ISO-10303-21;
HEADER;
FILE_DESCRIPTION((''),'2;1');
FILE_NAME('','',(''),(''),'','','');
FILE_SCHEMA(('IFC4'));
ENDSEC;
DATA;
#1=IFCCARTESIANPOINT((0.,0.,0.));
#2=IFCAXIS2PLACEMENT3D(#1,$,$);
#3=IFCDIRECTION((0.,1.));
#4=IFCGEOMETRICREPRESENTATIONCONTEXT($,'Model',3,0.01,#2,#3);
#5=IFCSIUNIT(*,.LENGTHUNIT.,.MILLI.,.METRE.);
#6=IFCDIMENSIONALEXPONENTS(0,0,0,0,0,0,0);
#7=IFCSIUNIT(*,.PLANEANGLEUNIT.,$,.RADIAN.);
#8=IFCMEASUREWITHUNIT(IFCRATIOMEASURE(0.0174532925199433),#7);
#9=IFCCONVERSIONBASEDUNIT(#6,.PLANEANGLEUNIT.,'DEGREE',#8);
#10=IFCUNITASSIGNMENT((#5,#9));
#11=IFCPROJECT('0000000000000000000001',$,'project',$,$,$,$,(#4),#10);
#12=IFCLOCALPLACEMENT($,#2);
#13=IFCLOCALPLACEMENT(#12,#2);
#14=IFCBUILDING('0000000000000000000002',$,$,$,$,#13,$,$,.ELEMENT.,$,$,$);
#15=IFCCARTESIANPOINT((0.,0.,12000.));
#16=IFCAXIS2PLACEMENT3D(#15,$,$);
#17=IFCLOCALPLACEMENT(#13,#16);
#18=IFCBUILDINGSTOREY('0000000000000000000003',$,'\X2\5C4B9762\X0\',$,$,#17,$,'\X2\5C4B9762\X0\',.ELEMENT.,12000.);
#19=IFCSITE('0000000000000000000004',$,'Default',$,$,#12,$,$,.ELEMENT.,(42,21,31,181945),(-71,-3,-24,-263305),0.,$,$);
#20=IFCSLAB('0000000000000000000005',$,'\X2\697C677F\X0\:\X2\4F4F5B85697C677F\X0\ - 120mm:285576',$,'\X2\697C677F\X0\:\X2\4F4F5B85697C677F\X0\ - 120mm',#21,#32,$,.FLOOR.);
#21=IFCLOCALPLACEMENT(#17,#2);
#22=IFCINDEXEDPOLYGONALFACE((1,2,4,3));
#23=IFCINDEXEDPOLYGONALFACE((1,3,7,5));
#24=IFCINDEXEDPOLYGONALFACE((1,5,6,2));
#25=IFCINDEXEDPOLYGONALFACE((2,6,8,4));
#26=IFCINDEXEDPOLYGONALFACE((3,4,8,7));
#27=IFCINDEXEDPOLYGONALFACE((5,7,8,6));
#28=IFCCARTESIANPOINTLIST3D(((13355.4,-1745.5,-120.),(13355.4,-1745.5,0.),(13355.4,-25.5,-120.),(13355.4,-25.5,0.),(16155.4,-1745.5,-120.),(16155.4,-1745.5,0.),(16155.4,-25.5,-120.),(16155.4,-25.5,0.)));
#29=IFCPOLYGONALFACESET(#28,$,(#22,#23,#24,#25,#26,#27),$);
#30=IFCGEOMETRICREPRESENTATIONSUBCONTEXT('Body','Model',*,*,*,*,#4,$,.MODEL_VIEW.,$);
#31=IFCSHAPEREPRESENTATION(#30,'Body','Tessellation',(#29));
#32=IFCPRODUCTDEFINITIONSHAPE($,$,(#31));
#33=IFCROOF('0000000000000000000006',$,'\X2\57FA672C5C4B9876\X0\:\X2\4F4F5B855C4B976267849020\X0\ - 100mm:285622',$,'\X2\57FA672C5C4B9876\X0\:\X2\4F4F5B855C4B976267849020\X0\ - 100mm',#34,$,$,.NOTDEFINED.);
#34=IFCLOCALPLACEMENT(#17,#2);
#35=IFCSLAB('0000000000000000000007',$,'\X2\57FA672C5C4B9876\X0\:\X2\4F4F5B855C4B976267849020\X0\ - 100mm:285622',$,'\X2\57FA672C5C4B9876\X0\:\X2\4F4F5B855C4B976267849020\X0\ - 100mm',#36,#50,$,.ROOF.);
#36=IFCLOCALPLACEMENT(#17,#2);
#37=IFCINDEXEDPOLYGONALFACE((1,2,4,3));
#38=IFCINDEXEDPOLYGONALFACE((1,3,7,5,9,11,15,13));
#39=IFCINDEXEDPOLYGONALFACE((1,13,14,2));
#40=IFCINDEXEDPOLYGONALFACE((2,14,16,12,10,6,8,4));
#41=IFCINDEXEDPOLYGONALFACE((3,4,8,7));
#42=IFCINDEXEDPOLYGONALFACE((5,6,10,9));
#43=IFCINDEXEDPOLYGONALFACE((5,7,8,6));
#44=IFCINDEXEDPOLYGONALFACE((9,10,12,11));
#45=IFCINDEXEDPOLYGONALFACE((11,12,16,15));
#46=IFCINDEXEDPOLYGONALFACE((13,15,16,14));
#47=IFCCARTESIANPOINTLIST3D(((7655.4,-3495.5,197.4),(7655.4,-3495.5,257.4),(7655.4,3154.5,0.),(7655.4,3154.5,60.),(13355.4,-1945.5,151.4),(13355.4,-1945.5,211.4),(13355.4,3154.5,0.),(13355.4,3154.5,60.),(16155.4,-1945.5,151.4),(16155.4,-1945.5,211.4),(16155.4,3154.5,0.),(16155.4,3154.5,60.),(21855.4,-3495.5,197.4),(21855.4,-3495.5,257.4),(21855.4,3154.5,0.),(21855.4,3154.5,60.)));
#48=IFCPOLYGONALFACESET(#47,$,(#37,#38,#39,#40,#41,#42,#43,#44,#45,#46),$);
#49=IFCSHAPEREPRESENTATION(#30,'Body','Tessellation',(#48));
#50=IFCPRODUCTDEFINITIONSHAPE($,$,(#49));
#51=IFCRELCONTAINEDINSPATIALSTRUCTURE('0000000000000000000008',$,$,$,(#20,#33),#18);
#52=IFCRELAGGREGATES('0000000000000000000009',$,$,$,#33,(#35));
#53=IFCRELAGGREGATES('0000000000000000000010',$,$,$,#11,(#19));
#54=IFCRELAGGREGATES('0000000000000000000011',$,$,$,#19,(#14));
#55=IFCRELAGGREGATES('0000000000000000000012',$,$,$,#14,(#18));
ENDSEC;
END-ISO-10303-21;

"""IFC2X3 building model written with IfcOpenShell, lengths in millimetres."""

from ifc_helpers import new_model, entity, si_unit, converted_unit, direction, frame, origin, origin_2d_with_axis, place, context, subcontext, project, spatial, polyline, rectangle, outline, extrude, element, aggregate, save


model = new_model("IFC2X3")

# Units and contexts
model_context = context("Model", 3, precision=0.01, world=origin(), true_north=direction((0.0, 1.0)))
body_context = subcontext(model_context, "Body", "Model", "MODEL_VIEW")
ifc_project = project(units=[si_unit("LENGTHUNIT", "METRE", prefix="MILLI"), converted_unit("PLANEANGLEUNIT", "DEGREE", entity("IfcRatioMeasure", 0.0174532925199433), si_unit("PLANEANGLEUNIT", "RADIAN"), dimensions=[0, 0, 0, 0, 0, 0, 0])], contexts=[model_context])

# Site, building, storey
site_placement = place(None, origin())
site = spatial("IfcSite", under=ifc_project, at=site_placement, Name="Default", CompositionType="ELEMENT", RefLatitude=(42, 21, 31, 181945), RefLongitude=(-71, -3, -24, -263305), RefElevation=0.0)
building_placement = place(site_placement, origin())
building = spatial("IfcBuilding", under=site, at=building_placement, CompositionType="ELEMENT")
storey_placement = place(building_placement, frame((0.0, 0.0, 12000.0)))
storey = spatial("IfcBuildingStorey", under=building, at=storey_placement, Name="屋面", LongName="屋面", CompositionType="ELEMENT", Elevation=12000.0)

# Slab
slab_1_placement = place(storey_placement, origin())
element("IfcSlab", 1, at=slab_1_placement, inside=storey, Name="楼板:住宅楼板 - 120mm:285576", ObjectType="楼板:住宅楼板 - 120mm", PredefinedType="FLOOR", context=body_context, shape_type="SweptSolid", body=[
    extrude(rectangle(XDim=1720.0, YDim=2800.0, at=origin_2d_with_axis()), frame((14755.4, -885.5, 0.0), z_axis=(0.0, 0.0, -1.0), x_axis=(0.0, 1.0, 0.0)), (0.0, 0.0, 1.0), 120.0),
])

# Roof, slab
roof_placement = place(storey_placement, frame((7655.4, -10145.5, 0.0)))
roof = element("IfcRoof", 2, at=roof_placement, inside=storey, Name="基本屋顶:住宅屋面构造 - 100mm:285622", ObjectType="基本屋顶:住宅屋面构造 - 100mm", ShapeType="NOTDEFINED")
slab_2_placement = place(roof_placement, origin())
slab_2 = element("IfcSlab", 3, at=slab_2_placement, Name="基本屋顶:住宅屋面构造 - 100mm:285622", ObjectType="基本屋顶:住宅屋面构造 - 100mm", PredefinedType="ROOF", context=body_context, shape_type="SweptSolid", body=[
    extrude(outline(polyline([(1400.0, 3326.5), (1400.0, -1775.8), (-1400.0, -1775.8), (-1400.0, 3326.5), (-7100.0, 3326.5), (-7100.0, -3326.5), (7100.0, -3326.5), (7100.0, 3326.5), (1400.0, 3326.5)])), frame((7100.0, 9975.0, 98.7), z_axis=(0.0, 0.029666, 0.99956), x_axis=(1.0, 0.0, 0.0)), (0.0, -0.029666, 0.99956), 60.0),
])
aggregate(roof, [slab_2])

save(model, "model.ifc")
